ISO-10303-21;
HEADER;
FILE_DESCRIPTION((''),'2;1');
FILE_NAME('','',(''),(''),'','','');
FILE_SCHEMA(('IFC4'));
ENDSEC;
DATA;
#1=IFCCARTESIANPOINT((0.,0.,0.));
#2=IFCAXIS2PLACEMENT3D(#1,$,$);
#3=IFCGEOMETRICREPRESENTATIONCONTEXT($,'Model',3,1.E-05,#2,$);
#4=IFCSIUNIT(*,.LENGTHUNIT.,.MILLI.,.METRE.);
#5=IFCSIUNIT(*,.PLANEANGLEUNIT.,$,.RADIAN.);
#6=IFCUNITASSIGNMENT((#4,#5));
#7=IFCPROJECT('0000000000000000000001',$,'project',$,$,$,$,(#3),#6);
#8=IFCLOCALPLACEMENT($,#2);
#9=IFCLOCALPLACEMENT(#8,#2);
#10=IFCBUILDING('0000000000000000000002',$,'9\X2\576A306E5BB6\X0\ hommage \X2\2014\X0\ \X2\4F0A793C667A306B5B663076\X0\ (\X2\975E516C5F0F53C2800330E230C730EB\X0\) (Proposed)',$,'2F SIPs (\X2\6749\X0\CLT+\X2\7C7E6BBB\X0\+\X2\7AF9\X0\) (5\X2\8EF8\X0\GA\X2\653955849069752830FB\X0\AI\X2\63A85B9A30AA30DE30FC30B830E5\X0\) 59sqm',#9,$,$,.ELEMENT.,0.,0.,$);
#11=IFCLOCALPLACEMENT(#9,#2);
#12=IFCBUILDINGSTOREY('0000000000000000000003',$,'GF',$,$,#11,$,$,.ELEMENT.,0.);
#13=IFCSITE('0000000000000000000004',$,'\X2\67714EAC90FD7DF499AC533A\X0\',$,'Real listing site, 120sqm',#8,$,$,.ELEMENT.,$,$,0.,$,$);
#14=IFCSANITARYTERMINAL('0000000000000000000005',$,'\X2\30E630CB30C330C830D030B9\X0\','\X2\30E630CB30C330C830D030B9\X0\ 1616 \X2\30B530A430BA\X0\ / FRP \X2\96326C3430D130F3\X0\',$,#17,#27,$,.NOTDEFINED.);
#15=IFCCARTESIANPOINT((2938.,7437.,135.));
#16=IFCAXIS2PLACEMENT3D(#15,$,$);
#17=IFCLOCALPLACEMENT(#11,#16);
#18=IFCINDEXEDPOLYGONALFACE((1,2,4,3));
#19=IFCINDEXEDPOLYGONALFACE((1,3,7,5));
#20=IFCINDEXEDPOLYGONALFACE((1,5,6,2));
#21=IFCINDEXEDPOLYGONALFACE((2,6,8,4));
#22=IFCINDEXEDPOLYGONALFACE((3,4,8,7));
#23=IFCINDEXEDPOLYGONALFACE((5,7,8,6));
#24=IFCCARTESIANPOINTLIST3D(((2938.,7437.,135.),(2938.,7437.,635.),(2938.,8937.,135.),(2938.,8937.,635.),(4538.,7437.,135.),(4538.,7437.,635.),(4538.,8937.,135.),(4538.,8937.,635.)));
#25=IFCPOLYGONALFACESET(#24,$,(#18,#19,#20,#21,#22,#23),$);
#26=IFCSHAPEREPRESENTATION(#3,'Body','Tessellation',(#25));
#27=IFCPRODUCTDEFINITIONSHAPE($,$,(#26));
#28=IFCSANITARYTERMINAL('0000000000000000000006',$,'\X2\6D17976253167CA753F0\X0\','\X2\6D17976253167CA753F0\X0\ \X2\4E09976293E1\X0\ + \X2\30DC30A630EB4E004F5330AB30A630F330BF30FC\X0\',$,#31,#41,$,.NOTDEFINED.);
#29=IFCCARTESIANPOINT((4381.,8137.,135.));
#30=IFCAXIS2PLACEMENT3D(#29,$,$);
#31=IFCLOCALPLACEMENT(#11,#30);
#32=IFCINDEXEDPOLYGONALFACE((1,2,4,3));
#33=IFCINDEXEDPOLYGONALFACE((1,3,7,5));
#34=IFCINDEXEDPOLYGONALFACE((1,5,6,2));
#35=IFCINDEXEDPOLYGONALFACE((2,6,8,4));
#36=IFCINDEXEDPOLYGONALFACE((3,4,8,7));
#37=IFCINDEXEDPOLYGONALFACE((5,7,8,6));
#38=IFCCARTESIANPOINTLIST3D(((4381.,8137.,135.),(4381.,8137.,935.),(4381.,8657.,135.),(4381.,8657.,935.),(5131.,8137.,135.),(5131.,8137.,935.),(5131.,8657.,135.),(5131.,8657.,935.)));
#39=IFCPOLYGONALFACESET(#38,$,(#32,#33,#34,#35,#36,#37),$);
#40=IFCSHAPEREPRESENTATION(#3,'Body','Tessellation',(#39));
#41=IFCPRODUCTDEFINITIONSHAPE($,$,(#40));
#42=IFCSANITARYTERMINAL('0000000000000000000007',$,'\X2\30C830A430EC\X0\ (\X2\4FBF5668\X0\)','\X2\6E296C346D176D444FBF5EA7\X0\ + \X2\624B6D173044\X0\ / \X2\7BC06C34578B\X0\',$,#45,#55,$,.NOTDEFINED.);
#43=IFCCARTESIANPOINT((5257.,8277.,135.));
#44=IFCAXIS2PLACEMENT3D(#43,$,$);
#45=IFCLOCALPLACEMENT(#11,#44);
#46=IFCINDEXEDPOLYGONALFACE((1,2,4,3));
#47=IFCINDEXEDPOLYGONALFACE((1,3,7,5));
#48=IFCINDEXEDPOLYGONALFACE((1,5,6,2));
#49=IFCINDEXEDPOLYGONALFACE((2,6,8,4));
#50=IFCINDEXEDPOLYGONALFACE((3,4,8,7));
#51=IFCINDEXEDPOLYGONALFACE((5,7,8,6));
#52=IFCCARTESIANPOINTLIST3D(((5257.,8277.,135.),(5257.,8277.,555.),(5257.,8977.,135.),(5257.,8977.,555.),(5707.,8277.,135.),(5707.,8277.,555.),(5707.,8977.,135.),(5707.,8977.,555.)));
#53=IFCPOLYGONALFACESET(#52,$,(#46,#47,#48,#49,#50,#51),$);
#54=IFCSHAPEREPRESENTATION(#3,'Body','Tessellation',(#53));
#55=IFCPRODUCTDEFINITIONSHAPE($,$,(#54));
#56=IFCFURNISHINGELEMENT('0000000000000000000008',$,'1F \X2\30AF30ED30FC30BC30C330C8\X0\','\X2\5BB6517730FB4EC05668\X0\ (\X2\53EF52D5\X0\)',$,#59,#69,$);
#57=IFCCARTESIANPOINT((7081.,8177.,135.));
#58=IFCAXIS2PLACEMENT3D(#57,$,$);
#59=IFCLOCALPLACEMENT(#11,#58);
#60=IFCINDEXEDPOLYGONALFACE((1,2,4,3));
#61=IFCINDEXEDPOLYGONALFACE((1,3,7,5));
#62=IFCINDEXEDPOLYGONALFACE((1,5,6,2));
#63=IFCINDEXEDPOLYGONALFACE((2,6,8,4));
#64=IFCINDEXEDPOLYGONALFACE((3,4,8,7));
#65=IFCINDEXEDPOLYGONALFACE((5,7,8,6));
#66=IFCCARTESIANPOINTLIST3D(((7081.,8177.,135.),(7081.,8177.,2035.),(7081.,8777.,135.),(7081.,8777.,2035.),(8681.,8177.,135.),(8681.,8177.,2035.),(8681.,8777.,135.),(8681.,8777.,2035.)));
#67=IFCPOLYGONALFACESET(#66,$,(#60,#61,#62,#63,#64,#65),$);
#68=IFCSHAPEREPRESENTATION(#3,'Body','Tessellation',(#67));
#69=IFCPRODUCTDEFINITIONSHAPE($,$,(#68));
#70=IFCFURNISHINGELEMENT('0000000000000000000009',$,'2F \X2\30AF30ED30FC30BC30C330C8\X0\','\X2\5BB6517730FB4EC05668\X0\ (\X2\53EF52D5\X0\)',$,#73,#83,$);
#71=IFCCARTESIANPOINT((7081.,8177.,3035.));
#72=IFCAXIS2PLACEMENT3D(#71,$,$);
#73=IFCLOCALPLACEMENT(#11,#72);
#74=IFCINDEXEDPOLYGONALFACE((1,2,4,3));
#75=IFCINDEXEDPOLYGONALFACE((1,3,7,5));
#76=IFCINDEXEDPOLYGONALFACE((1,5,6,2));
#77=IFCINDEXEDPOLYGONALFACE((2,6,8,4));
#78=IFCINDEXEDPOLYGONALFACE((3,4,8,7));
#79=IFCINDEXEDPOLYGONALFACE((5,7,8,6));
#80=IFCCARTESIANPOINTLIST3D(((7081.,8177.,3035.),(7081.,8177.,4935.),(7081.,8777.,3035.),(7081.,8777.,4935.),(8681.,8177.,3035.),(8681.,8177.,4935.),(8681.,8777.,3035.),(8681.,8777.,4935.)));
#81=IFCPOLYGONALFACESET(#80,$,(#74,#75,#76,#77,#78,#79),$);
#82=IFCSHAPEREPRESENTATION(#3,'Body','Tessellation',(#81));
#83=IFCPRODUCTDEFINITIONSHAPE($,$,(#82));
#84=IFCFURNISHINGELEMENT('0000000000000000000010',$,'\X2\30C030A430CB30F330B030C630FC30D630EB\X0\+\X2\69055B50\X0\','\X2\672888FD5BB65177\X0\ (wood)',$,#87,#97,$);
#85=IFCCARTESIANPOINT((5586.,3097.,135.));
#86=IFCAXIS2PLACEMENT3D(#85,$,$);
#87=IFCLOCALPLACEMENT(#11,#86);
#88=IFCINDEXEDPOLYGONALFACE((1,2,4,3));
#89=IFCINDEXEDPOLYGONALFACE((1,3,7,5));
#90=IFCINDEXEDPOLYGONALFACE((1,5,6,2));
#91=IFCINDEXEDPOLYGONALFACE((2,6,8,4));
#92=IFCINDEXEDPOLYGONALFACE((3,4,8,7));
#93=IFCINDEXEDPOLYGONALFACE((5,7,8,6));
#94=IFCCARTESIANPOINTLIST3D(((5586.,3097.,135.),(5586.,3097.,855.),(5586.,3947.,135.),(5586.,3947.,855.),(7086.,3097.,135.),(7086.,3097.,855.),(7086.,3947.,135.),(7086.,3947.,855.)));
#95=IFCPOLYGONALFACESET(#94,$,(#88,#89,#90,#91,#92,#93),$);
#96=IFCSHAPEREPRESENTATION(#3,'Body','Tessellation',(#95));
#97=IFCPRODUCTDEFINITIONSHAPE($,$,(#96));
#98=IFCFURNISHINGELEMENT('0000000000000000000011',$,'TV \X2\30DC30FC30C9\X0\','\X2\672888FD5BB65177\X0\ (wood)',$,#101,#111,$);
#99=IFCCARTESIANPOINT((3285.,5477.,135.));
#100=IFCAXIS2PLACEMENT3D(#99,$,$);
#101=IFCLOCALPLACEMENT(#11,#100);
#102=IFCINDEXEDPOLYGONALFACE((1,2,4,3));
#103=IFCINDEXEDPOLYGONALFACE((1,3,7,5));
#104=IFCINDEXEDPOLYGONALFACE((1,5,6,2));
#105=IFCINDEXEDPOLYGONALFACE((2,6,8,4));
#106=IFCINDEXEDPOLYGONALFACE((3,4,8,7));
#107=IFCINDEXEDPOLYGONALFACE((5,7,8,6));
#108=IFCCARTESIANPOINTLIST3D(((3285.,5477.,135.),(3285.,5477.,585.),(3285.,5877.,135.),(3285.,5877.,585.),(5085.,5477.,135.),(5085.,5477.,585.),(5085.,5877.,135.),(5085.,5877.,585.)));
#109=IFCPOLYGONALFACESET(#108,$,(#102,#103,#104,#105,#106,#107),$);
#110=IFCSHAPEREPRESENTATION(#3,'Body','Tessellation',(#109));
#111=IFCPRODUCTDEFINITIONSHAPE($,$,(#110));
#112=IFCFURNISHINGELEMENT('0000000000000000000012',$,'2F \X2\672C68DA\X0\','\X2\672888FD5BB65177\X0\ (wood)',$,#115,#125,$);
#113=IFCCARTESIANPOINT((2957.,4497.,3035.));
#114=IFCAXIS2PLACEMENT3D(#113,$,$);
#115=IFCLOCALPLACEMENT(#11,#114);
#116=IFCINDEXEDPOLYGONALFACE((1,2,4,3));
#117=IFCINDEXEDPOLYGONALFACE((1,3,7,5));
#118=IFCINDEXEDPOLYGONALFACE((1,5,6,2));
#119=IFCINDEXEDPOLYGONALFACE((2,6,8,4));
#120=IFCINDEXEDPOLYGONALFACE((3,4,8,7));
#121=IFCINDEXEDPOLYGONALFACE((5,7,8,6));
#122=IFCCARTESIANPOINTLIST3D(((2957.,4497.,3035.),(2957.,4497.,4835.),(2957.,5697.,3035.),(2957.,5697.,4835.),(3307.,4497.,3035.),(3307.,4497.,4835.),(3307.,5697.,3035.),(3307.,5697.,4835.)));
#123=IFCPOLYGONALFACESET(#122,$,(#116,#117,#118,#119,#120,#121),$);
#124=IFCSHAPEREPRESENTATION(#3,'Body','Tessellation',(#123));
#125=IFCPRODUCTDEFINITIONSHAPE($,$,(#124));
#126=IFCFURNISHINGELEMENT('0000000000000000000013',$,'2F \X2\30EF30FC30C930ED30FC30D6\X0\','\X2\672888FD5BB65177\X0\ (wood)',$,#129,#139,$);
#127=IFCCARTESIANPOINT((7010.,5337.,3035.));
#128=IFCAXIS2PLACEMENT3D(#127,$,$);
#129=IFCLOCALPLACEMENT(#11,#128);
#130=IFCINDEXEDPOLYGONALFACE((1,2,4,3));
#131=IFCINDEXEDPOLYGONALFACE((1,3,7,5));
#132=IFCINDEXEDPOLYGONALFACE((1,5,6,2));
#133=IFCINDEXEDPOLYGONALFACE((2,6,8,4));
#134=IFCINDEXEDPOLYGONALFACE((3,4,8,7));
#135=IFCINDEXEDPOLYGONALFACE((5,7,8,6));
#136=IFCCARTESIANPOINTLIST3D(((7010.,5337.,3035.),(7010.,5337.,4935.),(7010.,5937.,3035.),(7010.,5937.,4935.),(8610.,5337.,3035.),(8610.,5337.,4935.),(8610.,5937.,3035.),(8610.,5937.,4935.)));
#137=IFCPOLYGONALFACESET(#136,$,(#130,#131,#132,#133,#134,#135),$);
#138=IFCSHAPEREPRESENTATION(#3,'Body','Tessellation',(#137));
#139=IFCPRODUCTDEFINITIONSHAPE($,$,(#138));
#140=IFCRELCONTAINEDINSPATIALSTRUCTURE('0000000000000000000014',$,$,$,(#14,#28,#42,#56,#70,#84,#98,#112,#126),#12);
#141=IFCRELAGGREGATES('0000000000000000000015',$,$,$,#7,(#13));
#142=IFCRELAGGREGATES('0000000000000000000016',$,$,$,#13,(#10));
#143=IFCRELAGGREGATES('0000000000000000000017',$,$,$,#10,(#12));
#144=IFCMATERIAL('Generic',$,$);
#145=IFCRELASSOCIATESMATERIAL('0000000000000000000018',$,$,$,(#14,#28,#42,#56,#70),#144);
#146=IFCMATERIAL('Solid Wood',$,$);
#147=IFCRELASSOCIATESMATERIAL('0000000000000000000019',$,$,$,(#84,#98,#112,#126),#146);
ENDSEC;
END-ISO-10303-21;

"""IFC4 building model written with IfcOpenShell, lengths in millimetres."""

from ifc_helpers import new_model, si_unit, frame, frame_2d, origin, place, context, project, spatial, rectangle, extrude, material, element, save


model = new_model("IFC4")

# Units and contexts
model_context = context("Model", 3, precision=1e-05, world=origin())
ifc_project = project(units=[si_unit("LENGTHUNIT", "METRE", prefix="MILLI"), si_unit("PLANEANGLEUNIT", "RADIAN")], contexts=[model_context])

# Site, building, storey
site_placement = place(None, origin())
site = spatial("IfcSite", under=ifc_project, at=site_placement, Name="東京都練馬区", ObjectType="Real listing site, 120sqm", CompositionType="ELEMENT", RefElevation=0.0)
building_placement = place(site_placement, origin())
building = spatial("IfcBuilding", under=site, at=building_placement, Name="9坪の家 hommage — 伊礼智に学ぶ (非公式参考モデル) (Proposed)", ObjectType="2F SIPs (杉CLT+籾殻+竹) (5軸GA改善適用・AI推定オマージュ) 59sqm", CompositionType="ELEMENT", ElevationOfRefHeight=0.0, ElevationOfTerrain=0.0)
storey_placement = place(building_placement, origin())
storey = spatial("IfcBuildingStorey", under=building, at=storey_placement, Name="GF", CompositionType="ELEMENT", Elevation=0.0)

# Shared definitions
ifc_material_1 = material(Name="Solid Wood")

# Sanitary terminals
ifc_material_2 = material(Name="Generic")
sanitary_terminal_1_placement = place(storey_placement, frame((2938.0, 7437.0, 135.0)))
element("IfcSanitaryTerminal", 1, at=sanitary_terminal_1_placement, inside=storey, material=ifc_material_2, Name="ユニットバス", Description="ユニットバス 1616 サイズ / FRP 防水パン", PredefinedType="NOTDEFINED", context=model_context, shape_type="SweptSolid", body=[
    extrude(rectangle(XDim=1600.0, YDim=1500.0, at=frame_2d((800.0, 750.0))), frame((2938.0, 7437.0, 135.0)), (0.0, 0.0, 1.0), 500.0),
])
sanitary_terminal_2_placement = place(storey_placement, frame((4381.0, 8137.0, 135.0)))
element("IfcSanitaryTerminal", 2, at=sanitary_terminal_2_placement, inside=storey, material=ifc_material_2, Name="洗面化粧台", Description="洗面化粧台 三面鏡 + ボウル一体カウンター", PredefinedType="NOTDEFINED", context=model_context, shape_type="SweptSolid", body=[
    extrude(rectangle(XDim=750.0, YDim=520.0, at=frame_2d((375.0, 260.0))), frame((4381.0, 8137.0, 135.0)), (0.0, 0.0, 1.0), 800.0),
])
sanitary_terminal_3_placement = place(storey_placement, frame((5257.0, 8277.0, 135.0)))
element("IfcSanitaryTerminal", 3, at=sanitary_terminal_3_placement, inside=storey, material=ifc_material_2, Name="トイレ (便器)", Description="温水洗浄便座 + 手洗い / 節水型", PredefinedType="NOTDEFINED", context=model_context, shape_type="SweptSolid", body=[
    extrude(rectangle(XDim=450.0, YDim=700.0, at=frame_2d((225.0, 350.0))), frame((5257.0, 8277.0, 135.0)), (0.0, 0.0, 1.0), 420.0),
])

# Furnishing elements
furnishing_1_placement = place(storey_placement, frame((7081.0, 8177.0, 135.0)))
element("IfcFurnishingElement", 4, at=furnishing_1_placement, inside=storey, material=ifc_material_2, Name="1F クローゼット", Description="家具・什器 (可動)", context=model_context, shape_type="SweptSolid", body=[
    extrude(rectangle(XDim=1600.0, YDim=600.0, at=frame_2d((800.0, 300.0))), frame((7081.0, 8177.0, 135.0)), (0.0, 0.0, 1.0), 1900.0),
])
furnishing_2_placement = place(storey_placement, frame((7081.0, 8177.0, 3035.0)))
element("IfcFurnishingElement", 5, at=furnishing_2_placement, inside=storey, material=ifc_material_2, Name="2F クローゼット", Description="家具・什器 (可動)", context=model_context, shape_type="SweptSolid", body=[
    extrude(rectangle(XDim=1600.0, YDim=600.0, at=frame_2d((800.0, 300.0))), frame((7081.0, 8177.0, 3035.0)), (0.0, 0.0, 1.0), 1900.0),
])
furnishing_3_placement = place(storey_placement, frame((5586.0, 3097.0, 135.0)))
element("IfcFurnishingElement", 6, at=furnishing_3_placement, inside=storey, material=ifc_material_1, Name="ダイニングテーブル+椅子", Description="木製家具 (wood)", context=model_context, shape_type="SweptSolid", body=[
    extrude(rectangle(XDim=1500.0, YDim=850.0, at=frame_2d((750.0, 425.0))), frame((5586.0, 3097.0, 135.0)), (0.0, 0.0, 1.0), 720.0),
])
furnishing_4_placement = place(storey_placement, frame((3285.0, 5477.0, 135.0)))
element("IfcFurnishingElement", 7, at=furnishing_4_placement, inside=storey, material=ifc_material_1, Name="TV ボード", Description="木製家具 (wood)", context=model_context, shape_type="SweptSolid", body=[
    extrude(rectangle(XDim=1800.0, YDim=400.0, at=frame_2d((900.0, 200.0))), frame((3285.0, 5477.0, 135.0)), (0.0, 0.0, 1.0), 450.0),
])
furnishing_5_placement = place(storey_placement, frame((2957.0, 4497.0, 3035.0)))
element("IfcFurnishingElement", 8, at=furnishing_5_placement, inside=storey, material=ifc_material_1, Name="2F 本棚", Description="木製家具 (wood)", context=model_context, shape_type="SweptSolid", body=[
    extrude(rectangle(XDim=350.0, YDim=1200.0, at=frame_2d((175.0, 600.0))), frame((2957.0, 4497.0, 3035.0)), (0.0, 0.0, 1.0), 1800.0),
])
furnishing_6_placement = place(storey_placement, frame((7010.0, 5337.0, 3035.0)))
element("IfcFurnishingElement", 9, at=furnishing_6_placement, inside=storey, material=ifc_material_1, Name="2F ワードローブ", Description="木製家具 (wood)", context=model_context, shape_type="SweptSolid", body=[
    extrude(rectangle(XDim=1600.0, YDim=600.0, at=frame_2d((800.0, 300.0))), frame((7010.0, 5337.0, 3035.0)), (0.0, 0.0, 1.0), 1900.0),
])

save(model, "model.ifc")
